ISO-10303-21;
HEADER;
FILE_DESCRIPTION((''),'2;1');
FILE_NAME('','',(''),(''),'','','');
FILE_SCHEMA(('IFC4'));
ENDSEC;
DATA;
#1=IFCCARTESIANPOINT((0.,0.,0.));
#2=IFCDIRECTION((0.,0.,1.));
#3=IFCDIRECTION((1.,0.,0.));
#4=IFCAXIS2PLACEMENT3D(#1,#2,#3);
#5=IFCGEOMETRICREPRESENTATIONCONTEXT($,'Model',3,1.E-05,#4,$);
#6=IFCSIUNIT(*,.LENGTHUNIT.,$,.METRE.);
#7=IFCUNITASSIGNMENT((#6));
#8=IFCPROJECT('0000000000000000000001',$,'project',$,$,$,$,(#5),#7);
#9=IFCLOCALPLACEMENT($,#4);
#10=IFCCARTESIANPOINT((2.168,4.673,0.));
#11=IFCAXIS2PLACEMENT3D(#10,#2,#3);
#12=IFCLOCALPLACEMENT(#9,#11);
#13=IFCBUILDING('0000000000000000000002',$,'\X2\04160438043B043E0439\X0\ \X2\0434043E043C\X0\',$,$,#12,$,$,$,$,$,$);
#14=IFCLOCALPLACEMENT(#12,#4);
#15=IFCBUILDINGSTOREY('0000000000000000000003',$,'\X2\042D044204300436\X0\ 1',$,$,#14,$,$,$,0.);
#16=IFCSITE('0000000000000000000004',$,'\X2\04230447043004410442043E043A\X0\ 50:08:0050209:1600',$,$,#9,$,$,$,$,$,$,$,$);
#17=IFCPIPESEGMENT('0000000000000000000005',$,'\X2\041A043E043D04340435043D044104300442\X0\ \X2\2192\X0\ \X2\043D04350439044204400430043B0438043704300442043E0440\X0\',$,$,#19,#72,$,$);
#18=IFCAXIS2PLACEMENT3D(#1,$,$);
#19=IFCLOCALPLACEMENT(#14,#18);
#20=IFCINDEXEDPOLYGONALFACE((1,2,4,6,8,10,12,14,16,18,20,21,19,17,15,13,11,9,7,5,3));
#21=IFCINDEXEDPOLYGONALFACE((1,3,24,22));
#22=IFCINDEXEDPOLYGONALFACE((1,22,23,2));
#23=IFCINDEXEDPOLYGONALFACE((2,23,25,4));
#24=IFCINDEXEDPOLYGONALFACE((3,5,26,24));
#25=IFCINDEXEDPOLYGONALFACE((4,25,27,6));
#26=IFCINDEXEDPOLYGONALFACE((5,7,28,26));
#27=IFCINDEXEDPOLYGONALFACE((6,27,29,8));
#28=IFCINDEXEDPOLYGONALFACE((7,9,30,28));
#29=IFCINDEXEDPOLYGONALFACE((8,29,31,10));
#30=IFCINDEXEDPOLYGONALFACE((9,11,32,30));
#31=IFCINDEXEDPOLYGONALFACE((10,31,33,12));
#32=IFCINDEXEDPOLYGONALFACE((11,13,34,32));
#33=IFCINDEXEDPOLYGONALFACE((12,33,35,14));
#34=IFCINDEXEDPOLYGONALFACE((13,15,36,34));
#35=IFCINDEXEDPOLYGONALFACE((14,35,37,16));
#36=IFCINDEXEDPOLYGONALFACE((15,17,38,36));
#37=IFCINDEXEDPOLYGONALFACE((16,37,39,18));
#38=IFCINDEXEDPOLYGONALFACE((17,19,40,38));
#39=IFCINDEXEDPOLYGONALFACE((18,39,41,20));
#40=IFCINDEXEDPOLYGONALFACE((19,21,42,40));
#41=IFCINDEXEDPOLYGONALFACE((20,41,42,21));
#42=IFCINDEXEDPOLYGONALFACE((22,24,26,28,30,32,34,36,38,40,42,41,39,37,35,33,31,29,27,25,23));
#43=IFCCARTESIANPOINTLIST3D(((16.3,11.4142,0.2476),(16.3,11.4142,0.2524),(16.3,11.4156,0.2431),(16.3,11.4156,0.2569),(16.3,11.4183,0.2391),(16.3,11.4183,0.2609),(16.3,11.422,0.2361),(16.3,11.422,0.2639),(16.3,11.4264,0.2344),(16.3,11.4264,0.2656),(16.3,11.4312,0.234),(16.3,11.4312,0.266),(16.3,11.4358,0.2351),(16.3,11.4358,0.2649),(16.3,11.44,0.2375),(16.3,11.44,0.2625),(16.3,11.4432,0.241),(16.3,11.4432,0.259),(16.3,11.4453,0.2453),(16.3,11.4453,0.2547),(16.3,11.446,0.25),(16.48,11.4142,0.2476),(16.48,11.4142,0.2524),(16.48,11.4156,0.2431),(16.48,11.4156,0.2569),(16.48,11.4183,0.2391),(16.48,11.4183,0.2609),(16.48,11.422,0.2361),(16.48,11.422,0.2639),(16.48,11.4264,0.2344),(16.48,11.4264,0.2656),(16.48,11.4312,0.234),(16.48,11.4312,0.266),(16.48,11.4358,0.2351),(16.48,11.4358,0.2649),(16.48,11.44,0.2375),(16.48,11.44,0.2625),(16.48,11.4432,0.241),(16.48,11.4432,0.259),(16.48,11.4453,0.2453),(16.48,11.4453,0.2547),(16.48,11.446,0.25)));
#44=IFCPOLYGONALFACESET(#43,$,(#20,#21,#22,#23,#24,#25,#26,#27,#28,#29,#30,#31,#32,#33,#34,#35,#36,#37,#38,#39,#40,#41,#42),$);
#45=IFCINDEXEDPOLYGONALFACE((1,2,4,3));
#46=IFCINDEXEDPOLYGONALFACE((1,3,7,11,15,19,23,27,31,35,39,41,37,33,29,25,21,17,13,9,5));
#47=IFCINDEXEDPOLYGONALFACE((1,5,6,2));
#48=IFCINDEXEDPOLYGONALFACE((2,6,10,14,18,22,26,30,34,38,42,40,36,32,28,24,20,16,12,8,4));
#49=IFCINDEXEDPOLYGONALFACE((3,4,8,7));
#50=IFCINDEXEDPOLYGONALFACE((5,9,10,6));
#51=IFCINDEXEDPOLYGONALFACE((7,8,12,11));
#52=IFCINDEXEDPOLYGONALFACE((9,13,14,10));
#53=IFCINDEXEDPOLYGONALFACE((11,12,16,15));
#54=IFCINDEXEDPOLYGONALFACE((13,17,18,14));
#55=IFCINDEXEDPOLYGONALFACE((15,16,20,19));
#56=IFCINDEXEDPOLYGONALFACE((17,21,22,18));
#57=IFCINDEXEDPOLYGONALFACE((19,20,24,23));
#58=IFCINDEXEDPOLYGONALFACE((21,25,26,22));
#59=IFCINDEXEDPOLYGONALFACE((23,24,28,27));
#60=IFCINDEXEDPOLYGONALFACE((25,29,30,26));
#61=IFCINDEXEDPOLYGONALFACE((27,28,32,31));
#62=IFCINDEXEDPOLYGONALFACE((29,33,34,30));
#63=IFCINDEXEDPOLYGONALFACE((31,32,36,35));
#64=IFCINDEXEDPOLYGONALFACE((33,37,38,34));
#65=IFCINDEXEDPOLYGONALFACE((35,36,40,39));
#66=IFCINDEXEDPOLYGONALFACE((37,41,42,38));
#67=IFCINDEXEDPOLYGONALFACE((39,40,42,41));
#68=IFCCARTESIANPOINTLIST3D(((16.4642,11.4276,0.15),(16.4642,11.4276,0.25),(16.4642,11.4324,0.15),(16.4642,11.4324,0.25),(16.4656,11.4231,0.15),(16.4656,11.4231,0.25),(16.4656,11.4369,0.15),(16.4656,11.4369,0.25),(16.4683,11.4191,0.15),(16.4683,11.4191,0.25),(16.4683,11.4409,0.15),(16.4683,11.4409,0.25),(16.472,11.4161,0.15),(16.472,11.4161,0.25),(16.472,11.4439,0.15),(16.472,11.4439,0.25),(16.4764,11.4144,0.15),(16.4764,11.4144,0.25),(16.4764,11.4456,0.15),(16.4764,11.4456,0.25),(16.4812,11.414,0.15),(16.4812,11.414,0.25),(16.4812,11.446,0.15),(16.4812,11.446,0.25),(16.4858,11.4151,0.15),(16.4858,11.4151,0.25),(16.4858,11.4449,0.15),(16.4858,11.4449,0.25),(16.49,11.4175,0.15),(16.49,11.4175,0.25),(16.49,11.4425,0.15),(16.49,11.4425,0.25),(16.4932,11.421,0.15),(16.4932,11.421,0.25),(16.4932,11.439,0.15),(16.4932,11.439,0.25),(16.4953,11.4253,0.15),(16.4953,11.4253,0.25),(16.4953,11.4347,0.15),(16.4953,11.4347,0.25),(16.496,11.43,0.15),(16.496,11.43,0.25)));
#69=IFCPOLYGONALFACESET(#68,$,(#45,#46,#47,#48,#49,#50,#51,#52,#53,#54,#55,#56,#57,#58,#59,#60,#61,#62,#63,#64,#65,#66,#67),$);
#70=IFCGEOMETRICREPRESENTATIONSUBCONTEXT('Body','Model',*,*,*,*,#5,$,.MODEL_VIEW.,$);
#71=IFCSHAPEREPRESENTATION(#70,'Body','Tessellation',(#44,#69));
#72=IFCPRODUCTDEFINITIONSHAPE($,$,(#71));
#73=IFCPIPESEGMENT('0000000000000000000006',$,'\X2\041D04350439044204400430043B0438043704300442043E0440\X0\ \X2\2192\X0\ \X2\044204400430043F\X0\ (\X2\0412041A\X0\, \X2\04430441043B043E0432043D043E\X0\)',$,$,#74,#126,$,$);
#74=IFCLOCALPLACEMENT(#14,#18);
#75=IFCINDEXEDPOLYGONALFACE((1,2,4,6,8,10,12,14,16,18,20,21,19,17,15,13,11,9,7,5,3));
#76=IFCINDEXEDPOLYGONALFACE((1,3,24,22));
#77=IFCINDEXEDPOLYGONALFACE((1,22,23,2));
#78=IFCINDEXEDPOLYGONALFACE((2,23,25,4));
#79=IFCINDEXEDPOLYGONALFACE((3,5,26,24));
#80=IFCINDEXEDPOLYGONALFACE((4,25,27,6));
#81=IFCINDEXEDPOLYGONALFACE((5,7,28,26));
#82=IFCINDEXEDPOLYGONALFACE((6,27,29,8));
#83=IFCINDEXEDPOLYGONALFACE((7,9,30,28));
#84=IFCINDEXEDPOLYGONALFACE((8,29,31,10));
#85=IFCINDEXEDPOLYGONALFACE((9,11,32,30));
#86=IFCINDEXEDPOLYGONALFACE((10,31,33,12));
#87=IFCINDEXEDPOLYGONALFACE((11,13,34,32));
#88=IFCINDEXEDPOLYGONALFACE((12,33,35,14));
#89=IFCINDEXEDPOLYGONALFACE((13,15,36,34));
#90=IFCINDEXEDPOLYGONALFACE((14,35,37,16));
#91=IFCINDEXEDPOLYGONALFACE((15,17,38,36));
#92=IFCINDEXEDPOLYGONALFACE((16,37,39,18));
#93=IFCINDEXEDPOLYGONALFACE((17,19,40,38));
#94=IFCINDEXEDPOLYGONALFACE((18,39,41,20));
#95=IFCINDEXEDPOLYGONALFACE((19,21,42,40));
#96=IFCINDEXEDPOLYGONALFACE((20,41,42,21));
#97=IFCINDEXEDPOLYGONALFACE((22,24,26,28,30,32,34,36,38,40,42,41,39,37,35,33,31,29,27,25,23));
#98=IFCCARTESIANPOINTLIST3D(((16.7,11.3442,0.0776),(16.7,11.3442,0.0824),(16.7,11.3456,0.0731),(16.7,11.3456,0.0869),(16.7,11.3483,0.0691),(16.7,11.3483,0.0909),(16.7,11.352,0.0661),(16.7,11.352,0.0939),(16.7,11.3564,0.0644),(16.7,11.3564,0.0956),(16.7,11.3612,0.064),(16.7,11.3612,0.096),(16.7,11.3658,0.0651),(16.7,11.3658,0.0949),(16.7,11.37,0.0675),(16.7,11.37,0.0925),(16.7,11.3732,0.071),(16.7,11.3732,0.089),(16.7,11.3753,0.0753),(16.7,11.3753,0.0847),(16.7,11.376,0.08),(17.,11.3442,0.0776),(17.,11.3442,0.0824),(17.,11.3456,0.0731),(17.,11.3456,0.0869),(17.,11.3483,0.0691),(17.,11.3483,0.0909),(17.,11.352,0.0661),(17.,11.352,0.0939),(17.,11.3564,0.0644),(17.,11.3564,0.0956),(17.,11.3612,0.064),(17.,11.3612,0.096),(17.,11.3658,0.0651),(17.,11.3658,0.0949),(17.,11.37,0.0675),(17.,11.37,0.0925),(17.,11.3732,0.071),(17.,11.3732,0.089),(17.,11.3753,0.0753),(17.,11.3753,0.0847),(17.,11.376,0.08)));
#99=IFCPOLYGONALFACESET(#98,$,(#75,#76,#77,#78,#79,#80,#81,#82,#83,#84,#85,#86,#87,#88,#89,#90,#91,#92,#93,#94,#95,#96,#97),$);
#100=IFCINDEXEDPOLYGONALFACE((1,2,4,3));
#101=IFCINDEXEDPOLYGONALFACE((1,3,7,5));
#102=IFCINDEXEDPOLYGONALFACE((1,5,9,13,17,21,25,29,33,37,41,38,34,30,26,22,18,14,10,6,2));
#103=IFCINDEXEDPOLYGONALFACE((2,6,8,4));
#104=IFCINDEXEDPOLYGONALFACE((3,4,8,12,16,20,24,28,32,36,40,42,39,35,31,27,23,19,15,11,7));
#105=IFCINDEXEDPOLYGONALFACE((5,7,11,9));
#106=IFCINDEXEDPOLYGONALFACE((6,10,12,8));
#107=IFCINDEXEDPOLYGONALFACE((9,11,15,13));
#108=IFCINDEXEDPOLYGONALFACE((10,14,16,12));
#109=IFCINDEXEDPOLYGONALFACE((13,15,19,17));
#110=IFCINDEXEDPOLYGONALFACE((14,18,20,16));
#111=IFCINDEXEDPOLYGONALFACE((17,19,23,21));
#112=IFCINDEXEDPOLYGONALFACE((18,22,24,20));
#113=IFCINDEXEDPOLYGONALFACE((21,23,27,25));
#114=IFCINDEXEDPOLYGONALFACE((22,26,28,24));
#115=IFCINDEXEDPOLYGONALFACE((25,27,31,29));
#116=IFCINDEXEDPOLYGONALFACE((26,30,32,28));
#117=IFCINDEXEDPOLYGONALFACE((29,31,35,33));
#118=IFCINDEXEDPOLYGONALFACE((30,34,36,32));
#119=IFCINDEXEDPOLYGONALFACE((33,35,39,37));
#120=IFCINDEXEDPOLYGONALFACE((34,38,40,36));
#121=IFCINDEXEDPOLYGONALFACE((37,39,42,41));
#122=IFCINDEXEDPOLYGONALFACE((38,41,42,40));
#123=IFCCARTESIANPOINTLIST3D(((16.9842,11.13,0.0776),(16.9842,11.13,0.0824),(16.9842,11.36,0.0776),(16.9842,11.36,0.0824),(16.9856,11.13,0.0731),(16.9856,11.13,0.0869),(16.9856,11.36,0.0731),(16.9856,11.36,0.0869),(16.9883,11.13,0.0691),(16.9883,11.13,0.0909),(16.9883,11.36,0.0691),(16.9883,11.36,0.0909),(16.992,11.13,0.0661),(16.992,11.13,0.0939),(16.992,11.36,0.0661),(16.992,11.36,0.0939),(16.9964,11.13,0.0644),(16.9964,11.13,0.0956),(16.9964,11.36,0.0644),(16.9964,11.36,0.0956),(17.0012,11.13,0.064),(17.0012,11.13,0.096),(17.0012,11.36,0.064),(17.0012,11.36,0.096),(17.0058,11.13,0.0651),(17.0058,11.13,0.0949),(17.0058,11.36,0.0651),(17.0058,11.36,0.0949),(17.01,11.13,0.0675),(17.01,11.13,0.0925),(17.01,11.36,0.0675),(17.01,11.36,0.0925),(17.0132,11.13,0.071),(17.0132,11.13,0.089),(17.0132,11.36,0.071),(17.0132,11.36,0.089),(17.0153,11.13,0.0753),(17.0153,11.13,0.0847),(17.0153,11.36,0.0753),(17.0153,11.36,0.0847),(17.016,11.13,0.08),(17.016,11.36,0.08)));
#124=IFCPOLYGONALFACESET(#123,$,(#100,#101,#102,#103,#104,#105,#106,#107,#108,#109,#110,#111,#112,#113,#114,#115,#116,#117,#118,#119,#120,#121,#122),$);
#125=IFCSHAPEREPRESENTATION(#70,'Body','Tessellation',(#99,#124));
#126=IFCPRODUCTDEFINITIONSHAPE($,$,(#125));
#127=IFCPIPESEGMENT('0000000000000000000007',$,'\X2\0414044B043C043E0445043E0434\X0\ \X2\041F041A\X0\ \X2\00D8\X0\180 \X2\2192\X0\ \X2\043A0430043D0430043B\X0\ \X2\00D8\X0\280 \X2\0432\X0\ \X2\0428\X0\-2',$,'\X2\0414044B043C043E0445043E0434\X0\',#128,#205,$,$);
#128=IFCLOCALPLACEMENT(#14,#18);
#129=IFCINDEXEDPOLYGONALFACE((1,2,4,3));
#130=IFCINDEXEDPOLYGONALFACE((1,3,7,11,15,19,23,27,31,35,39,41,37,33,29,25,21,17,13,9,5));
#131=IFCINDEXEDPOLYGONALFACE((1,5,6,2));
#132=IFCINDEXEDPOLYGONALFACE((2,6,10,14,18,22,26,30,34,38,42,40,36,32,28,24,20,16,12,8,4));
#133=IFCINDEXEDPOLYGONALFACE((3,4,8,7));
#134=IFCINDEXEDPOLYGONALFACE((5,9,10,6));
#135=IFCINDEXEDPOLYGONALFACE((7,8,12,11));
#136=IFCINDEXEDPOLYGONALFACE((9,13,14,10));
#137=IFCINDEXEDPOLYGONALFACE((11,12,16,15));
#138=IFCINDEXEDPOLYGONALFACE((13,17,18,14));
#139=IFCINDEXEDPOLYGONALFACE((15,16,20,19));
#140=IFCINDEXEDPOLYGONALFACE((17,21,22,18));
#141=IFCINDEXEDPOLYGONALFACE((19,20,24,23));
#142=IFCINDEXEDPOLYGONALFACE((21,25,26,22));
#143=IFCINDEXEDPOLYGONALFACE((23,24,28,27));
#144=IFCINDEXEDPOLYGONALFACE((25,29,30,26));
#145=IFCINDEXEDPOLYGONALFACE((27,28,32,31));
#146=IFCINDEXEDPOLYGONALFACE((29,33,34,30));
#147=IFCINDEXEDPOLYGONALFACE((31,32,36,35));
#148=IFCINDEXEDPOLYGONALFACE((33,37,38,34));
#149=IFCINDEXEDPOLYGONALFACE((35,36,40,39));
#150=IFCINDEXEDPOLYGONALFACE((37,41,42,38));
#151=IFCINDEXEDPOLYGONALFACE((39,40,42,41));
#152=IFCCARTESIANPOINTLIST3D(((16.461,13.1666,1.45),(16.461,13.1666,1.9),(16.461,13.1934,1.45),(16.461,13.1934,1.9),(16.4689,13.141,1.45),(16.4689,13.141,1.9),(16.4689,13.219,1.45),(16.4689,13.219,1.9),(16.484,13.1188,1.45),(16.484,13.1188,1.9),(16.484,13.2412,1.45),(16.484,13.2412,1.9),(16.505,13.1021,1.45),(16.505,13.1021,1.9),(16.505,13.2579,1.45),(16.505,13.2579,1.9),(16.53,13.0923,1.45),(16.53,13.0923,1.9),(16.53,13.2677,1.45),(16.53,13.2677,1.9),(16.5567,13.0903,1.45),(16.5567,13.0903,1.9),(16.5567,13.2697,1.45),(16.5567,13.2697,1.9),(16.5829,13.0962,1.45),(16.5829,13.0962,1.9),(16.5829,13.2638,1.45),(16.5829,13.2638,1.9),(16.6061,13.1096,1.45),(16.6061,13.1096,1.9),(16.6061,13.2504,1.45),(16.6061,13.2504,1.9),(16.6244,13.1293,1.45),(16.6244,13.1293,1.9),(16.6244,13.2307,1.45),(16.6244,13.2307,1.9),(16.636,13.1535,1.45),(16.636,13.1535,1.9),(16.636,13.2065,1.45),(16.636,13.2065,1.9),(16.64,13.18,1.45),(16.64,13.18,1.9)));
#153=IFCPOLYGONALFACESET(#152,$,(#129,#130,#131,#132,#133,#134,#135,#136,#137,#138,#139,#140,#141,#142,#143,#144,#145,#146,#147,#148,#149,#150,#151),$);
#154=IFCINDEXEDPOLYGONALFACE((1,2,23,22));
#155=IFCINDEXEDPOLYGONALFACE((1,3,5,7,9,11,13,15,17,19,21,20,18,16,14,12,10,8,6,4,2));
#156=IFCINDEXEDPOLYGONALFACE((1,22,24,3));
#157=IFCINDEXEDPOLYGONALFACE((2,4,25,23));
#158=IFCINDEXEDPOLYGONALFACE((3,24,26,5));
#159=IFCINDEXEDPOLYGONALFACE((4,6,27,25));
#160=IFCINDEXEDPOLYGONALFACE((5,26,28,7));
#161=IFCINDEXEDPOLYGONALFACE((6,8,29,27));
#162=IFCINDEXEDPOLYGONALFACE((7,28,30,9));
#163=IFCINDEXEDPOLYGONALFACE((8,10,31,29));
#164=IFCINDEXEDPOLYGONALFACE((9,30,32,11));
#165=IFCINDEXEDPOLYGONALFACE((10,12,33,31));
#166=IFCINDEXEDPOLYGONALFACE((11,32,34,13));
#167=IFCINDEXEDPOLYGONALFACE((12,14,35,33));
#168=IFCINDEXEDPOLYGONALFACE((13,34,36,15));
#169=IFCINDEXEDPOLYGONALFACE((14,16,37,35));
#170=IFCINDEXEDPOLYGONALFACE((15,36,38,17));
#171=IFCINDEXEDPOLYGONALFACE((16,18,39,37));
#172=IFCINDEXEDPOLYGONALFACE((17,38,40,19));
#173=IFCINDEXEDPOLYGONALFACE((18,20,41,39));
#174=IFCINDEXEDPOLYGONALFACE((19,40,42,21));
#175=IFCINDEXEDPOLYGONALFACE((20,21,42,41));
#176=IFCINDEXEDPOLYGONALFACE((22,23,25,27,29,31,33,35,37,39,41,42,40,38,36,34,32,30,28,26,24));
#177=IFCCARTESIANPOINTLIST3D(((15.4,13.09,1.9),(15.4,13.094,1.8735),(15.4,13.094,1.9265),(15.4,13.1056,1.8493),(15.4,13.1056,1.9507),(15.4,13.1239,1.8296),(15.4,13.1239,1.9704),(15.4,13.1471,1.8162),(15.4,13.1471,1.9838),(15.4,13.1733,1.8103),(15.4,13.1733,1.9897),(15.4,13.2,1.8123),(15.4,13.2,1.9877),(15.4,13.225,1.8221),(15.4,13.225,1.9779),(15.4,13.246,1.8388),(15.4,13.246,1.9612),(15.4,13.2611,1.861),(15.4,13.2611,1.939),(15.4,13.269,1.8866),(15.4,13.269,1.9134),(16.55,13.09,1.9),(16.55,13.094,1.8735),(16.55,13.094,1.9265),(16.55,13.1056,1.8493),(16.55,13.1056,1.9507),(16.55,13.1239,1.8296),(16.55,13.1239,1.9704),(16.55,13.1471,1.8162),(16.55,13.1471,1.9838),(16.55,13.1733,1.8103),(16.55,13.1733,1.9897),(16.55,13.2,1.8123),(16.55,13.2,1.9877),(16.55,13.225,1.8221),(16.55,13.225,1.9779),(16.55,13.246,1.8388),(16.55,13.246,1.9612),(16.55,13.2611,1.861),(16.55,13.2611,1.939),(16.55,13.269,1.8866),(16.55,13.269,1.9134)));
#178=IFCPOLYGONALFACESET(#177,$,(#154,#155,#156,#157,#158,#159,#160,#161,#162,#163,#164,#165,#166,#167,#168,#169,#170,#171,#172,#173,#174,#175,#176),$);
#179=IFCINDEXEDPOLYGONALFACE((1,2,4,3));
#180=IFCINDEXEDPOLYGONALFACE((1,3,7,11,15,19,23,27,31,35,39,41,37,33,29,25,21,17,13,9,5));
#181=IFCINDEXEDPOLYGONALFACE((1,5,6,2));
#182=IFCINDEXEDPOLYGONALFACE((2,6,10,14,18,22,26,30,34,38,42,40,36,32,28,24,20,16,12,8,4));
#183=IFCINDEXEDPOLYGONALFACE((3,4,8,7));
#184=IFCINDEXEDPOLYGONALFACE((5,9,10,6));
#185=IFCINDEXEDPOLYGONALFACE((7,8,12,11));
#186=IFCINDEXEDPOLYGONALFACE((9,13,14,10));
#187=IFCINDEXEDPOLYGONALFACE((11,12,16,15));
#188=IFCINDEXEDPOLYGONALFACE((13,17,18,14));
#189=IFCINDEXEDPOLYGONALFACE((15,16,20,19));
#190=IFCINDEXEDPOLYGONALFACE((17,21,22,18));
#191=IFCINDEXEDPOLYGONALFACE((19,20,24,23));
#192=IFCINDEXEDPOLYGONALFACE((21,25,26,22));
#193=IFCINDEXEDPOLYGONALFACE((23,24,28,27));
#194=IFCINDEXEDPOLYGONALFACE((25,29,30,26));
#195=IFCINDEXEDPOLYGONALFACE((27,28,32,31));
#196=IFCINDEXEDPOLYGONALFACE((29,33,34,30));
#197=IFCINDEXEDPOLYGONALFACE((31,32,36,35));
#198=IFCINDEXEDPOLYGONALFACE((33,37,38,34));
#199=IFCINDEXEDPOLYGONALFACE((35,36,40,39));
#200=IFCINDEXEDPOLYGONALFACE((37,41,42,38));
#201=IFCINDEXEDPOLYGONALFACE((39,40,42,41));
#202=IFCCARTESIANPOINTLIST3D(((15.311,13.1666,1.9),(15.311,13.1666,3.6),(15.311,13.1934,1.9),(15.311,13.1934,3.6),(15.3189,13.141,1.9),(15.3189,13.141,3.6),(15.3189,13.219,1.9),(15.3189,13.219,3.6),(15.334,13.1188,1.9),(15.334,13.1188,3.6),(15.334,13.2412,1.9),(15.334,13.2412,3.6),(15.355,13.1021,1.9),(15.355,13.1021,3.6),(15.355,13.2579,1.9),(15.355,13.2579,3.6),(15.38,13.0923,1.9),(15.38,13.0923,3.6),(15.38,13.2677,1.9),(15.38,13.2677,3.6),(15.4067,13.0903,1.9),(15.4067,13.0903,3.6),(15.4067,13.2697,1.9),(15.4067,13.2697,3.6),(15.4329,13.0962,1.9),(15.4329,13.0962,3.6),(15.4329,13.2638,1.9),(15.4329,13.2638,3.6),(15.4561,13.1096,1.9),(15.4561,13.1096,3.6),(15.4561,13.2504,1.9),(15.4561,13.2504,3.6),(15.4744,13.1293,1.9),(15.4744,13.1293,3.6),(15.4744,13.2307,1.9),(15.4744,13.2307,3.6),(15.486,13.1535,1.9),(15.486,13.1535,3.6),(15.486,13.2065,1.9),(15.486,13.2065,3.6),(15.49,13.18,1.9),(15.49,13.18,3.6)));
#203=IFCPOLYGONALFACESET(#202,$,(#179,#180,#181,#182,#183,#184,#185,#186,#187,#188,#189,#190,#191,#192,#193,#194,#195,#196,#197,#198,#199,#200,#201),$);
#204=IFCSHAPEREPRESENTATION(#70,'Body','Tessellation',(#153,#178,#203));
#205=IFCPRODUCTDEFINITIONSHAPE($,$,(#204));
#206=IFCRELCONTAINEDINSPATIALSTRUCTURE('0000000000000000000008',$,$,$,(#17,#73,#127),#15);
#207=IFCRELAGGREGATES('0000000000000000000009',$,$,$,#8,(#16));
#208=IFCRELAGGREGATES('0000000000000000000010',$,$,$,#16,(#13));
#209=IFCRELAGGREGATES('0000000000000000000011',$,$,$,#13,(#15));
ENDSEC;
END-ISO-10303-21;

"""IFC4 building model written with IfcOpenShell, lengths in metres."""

from ifc_helpers import new_model, si_unit, frame, origin_with_axes, origin_2d, place, context, subcontext, project, spatial, circle, extrude, element, save


model = new_model("IFC4")

# Units and contexts
model_context = context("Model", 3, precision=1e-05, world=origin_with_axes())
body_context = subcontext(model_context, "Body", "Model", "MODEL_VIEW")
ifc_project = project(units=[si_unit("LENGTHUNIT", "METRE")], contexts=[model_context])

# Site, building, storey
site_placement = place(None, origin_with_axes())
site = spatial("IfcSite", under=ifc_project, at=site_placement, Name="Участок 50:08:0050209:1600")
building_placement = place(site_placement, frame((2.168, 4.673, 0.0), z_axis=(0.0, 0.0, 1.0), x_axis=(1.0, 0.0, 0.0)))
building = spatial("IfcBuilding", under=site, at=building_placement, Name="Жилой дом")
storey_placement = place(building_placement, origin_with_axes())
storey = spatial("IfcBuildingStorey", under=building, at=storey_placement, Name="Этаж 1", Elevation=0.0)

# Pipe segments
pipe_segment_1_placement = place(storey_placement, origin_with_axes())
element("IfcPipeSegment", 1, at=pipe_segment_1_placement, inside=storey, Name="Конденсат → нейтрализатор", context=body_context, shape_type="SweptSolid", body=[
    extrude(circle(Radius=0.016, at=origin_2d()), frame((16.3, 11.43, 0.25), z_axis=(1.0, 0.0, 0.0), x_axis=(0.0, 1.0, 0.0)), (0.0, 0.0, 1.0), 0.18),
    extrude(circle(Radius=0.016, at=origin_2d()), frame((16.48, 11.43, 0.25), z_axis=(0.0, 0.0, -1.0), x_axis=(1.0, 0.0, 0.0)), (0.0, 0.0, 1.0), 0.1),
])
pipe_segment_2_placement = place(storey_placement, origin_with_axes())
element("IfcPipeSegment", 2, at=pipe_segment_2_placement, inside=storey, Name="Нейтрализатор → трап (ВК, условно)", context=body_context, shape_type="SweptSolid", body=[
    extrude(circle(Radius=0.016, at=origin_2d()), frame((16.7, 11.36, 0.08), z_axis=(1.0, 0.0, 0.0), x_axis=(0.0, 1.0, 0.0)), (0.0, 0.0, 1.0), 0.3),
    extrude(circle(Radius=0.016, at=origin_2d()), frame((17.0, 11.36, 0.08), z_axis=(0.0, -1.0, 0.0), x_axis=(1.0, 0.0, 0.0)), (0.0, 0.0, 1.0), 0.23),
])
pipe_segment_3_placement = place(storey_placement, origin_with_axes())
element("IfcPipeSegment", 3, at=pipe_segment_3_placement, inside=storey, Name="Дымоход ПК Ø180 → канал Ø280 в Ш-2", ObjectType="Дымоход", context=body_context, shape_type="SweptSolid", body=[
    extrude(circle(Radius=0.09, at=origin_2d()), frame((16.55, 13.18, 1.45), z_axis=(0.0, 0.0, 1.0), x_axis=(1.0, 0.0, 0.0)), (0.0, 0.0, 1.0), 0.45),
    extrude(circle(Radius=0.09, at=origin_2d()), frame((16.55, 13.18, 1.9), z_axis=(-1.0, 0.0, 0.0), x_axis=(0.0, -1.0, 0.0)), (0.0, 0.0, 1.0), 1.15),
    extrude(circle(Radius=0.09, at=origin_2d()), frame((15.4, 13.18, 1.9), z_axis=(0.0, 0.0, 1.0), x_axis=(1.0, 0.0, 0.0)), (0.0, 0.0, 1.0), 1.7),
])

save(model, "model.ifc")
